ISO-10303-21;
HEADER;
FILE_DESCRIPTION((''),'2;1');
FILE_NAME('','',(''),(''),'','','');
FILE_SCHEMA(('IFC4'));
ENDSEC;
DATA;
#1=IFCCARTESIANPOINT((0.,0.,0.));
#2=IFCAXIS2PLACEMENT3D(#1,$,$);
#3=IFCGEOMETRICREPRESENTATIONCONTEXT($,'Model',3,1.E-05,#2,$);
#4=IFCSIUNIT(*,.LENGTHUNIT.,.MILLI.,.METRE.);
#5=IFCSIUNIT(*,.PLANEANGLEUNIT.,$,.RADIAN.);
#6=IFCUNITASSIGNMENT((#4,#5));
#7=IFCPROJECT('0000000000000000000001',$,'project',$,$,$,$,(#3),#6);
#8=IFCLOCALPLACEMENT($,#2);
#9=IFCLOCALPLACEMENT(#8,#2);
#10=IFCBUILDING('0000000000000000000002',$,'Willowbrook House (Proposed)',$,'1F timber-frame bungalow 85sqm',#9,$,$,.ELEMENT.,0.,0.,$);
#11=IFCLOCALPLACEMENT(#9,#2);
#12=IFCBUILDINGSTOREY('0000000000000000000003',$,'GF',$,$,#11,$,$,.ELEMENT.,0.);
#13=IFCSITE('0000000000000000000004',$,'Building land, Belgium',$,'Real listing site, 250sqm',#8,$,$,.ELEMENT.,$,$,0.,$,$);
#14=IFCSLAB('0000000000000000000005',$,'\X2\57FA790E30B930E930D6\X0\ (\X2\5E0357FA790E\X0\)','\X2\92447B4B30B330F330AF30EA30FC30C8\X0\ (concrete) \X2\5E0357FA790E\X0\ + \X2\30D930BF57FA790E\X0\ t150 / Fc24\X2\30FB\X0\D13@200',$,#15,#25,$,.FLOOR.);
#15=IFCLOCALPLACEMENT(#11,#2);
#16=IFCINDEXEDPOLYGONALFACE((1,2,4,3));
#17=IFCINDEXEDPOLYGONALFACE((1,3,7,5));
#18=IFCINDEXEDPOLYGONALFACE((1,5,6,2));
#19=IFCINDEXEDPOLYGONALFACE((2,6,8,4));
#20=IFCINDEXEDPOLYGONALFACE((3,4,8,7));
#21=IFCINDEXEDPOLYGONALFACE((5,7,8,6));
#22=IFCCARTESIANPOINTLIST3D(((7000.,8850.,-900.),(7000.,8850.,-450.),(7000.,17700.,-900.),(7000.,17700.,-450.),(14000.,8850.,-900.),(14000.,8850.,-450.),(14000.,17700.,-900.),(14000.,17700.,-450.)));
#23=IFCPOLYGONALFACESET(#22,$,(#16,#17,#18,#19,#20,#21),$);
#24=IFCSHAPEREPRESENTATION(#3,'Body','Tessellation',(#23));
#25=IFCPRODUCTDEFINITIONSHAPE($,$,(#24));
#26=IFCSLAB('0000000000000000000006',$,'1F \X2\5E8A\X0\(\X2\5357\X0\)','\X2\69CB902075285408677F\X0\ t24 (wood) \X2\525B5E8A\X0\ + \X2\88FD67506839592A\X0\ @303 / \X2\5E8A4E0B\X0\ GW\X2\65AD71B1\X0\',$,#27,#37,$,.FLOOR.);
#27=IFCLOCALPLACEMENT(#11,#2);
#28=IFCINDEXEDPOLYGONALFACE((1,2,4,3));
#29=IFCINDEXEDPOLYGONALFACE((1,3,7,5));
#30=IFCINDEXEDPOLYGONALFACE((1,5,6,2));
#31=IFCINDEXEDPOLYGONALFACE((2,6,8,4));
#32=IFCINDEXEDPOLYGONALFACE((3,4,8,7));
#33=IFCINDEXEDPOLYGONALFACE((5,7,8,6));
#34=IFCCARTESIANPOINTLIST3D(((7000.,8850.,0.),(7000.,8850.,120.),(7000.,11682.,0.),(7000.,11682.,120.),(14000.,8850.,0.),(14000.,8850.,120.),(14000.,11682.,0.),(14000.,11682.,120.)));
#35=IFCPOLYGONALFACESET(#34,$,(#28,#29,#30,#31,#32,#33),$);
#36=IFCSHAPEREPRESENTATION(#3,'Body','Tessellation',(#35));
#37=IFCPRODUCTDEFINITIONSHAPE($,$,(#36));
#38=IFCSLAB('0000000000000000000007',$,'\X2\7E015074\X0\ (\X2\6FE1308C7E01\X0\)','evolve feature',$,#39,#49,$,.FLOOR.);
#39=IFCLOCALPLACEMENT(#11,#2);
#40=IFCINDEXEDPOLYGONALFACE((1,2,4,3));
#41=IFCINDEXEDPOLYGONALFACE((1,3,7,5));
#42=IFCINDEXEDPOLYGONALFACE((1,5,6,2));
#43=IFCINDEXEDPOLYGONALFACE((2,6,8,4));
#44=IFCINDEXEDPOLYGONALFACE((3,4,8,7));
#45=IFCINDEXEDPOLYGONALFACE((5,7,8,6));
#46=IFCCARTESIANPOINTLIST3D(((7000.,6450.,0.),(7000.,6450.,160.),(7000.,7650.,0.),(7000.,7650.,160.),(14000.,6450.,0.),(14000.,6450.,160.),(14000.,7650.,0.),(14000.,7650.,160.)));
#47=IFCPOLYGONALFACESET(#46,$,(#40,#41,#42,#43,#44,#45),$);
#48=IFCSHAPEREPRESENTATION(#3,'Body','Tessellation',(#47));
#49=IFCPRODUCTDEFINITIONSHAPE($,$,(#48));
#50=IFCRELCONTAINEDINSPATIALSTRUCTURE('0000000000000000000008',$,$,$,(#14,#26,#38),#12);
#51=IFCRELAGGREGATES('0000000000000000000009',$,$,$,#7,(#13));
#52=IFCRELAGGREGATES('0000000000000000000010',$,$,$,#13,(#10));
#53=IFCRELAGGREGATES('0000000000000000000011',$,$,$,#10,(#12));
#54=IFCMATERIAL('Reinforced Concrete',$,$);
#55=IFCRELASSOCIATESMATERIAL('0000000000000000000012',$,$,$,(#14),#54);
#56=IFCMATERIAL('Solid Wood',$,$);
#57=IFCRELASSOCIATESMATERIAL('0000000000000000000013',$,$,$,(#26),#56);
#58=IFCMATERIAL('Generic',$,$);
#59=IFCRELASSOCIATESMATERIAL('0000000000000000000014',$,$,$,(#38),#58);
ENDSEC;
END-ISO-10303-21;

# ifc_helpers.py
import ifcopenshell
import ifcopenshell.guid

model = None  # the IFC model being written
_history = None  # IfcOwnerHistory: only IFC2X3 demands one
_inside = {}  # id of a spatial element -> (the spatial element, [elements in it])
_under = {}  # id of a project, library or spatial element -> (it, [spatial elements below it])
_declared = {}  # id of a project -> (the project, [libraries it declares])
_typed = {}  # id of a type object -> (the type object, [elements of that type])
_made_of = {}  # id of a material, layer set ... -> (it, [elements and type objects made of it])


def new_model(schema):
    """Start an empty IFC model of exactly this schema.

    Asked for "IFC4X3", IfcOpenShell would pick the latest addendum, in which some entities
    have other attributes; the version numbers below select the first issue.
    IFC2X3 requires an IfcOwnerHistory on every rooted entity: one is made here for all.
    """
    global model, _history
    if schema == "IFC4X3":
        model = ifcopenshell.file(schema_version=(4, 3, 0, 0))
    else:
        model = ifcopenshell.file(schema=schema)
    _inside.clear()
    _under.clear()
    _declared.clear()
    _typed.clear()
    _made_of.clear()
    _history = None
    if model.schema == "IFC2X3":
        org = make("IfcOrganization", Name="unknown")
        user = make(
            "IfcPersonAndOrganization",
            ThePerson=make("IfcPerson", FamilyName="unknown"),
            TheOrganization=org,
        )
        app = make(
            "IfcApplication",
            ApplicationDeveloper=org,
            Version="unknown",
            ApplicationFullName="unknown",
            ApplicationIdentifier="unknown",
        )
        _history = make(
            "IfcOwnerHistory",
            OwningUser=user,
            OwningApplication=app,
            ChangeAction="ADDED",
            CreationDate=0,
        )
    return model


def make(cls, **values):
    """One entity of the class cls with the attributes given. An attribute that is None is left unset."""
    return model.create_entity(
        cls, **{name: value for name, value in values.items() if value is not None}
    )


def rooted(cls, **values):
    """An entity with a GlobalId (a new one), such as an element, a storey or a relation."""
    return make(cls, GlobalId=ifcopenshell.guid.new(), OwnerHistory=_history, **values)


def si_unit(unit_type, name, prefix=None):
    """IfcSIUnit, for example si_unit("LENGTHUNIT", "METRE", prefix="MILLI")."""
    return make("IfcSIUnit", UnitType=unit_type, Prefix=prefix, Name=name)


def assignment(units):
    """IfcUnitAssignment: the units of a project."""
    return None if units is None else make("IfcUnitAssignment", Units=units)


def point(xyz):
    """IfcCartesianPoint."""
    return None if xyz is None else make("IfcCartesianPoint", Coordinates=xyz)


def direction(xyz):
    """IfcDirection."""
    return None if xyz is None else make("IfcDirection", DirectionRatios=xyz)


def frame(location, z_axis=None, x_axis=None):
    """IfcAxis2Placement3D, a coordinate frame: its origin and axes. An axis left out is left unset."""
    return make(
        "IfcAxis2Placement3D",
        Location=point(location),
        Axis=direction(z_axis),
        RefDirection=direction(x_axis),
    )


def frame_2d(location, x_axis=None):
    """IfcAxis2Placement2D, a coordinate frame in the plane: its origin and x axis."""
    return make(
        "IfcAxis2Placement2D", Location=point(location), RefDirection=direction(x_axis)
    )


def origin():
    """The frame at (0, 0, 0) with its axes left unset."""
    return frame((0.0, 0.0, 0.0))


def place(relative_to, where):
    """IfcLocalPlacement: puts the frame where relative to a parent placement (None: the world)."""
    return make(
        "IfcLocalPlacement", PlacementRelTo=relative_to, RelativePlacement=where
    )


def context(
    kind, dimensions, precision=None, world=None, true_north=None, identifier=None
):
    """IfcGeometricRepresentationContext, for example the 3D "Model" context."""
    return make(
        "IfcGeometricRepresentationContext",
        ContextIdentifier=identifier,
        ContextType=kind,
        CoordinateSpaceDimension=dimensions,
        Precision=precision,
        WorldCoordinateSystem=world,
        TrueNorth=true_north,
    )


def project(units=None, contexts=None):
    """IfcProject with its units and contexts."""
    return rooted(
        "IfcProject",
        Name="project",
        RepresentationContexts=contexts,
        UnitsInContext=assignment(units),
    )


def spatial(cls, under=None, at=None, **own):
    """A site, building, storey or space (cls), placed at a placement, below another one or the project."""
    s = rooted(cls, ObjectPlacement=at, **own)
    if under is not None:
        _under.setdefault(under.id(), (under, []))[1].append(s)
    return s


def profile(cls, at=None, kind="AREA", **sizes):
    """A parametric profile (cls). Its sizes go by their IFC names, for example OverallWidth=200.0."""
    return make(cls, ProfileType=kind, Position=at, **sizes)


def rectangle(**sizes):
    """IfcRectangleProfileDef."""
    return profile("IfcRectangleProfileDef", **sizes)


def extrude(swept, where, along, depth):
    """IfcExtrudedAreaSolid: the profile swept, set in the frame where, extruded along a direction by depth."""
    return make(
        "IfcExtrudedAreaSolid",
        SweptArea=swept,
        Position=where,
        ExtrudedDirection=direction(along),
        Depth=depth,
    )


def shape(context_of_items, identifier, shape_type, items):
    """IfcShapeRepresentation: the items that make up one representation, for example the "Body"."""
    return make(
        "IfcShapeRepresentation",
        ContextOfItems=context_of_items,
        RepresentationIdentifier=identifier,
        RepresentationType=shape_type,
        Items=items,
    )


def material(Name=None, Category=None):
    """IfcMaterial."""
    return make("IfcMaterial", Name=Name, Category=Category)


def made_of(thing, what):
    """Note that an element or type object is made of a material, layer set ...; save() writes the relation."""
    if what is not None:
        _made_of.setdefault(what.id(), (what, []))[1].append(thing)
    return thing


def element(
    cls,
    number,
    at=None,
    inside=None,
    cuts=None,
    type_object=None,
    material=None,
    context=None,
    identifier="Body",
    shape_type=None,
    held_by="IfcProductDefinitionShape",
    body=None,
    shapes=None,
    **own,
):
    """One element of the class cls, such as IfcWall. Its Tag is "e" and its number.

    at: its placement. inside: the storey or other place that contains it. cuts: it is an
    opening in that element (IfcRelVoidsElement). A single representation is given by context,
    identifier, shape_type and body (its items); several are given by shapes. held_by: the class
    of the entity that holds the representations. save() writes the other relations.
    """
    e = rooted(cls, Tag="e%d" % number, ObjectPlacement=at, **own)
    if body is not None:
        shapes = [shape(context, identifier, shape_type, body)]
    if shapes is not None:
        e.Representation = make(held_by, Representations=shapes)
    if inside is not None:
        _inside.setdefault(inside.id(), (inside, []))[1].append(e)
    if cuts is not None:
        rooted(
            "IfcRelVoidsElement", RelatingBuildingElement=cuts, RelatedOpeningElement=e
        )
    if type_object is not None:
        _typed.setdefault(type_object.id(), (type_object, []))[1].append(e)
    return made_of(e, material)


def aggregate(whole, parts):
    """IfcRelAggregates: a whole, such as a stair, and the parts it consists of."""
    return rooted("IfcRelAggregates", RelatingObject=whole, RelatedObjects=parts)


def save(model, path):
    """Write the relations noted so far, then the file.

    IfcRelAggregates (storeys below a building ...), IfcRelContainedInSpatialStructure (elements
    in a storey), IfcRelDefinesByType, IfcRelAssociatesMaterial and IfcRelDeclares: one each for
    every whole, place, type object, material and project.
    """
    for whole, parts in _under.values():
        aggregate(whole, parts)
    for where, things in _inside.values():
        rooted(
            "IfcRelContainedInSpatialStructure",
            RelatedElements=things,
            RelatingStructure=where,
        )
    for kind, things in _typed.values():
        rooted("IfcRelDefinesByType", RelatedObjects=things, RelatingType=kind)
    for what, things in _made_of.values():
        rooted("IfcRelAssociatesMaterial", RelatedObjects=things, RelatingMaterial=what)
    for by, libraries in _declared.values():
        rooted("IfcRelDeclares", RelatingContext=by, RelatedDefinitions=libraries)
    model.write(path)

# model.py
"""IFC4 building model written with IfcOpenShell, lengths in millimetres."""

from ifc_helpers import new_model, si_unit, frame, frame_2d, origin, place, context, project, spatial, rectangle, extrude, material, element, save


model = new_model("IFC4")

# Units and contexts
model_context = context("Model", 3, precision=1e-05, world=origin())
ifc_project = project(units=[si_unit("LENGTHUNIT", "METRE", prefix="MILLI"), si_unit("PLANEANGLEUNIT", "RADIAN")], contexts=[model_context])

# Site, building, storey
site_placement = place(None, origin())
site = spatial("IfcSite", under=ifc_project, at=site_placement, Name="Building land, Belgium", ObjectType="Real listing site, 250sqm", CompositionType="ELEMENT", RefElevation=0.0)
building_placement = place(site_placement, origin())
building = spatial("IfcBuilding", under=site, at=building_placement, Name="Willowbrook House (Proposed)", ObjectType="1F timber-frame bungalow 85sqm", CompositionType="ELEMENT", ElevationOfRefHeight=0.0, ElevationOfTerrain=0.0)
storey_placement = place(building_placement, origin())
storey = spatial("IfcBuildingStorey", under=building, at=storey_placement, Name="GF", CompositionType="ELEMENT", Elevation=0.0)

# Slabs
ifc_material_1 = material(Name="Reinforced Concrete")
slab_1_placement = place(storey_placement, frame((3500.0, 4425.0, -450.0)))
element("IfcSlab", 1, at=slab_1_placement, inside=storey, material=ifc_material_1, Name="基礎スラブ (布基礎)", Description="鉄筋コンクリート (concrete) 布基礎 + ベタ基礎 t150 / Fc24・D13@200", PredefinedType="FLOOR", context=model_context, shape_type="SweptSolid", body=[
    extrude(rectangle(XDim=7000.0, YDim=8850.0, at=frame_2d((3500.0, 4425.0))), frame((3500.0, 4425.0, -450.0)), (0.0, 0.0, 1.0), 450.0),
])
ifc_material_2 = material(Name="Solid Wood")
slab_2_placement = place(storey_placement, frame((3500.0, 4425.0, 0.0)))
element("IfcSlab", 2, at=slab_2_placement, inside=storey, material=ifc_material_2, Name="1F 床(南)", Description="構造用合板 t24 (wood) 剛床 + 製材根太 @303 / 床下 GW断熱", PredefinedType="FLOOR", context=model_context, shape_type="SweptSolid", body=[
    extrude(rectangle(XDim=7000.0, YDim=2832.0, at=frame_2d((3500.0, 1416.0))), frame((3500.0, 4425.0, 0.0)), (0.0, 0.0, 1.0), 120.0),
])
ifc_material_3 = material(Name="Generic")
slab_3_placement = place(storey_placement, frame((3500.0, 3225.0, 0.0)))
element("IfcSlab", 3, at=slab_3_placement, inside=storey, material=ifc_material_3, Name="縁側 (濡れ縁)", Description="evolve feature", PredefinedType="FLOOR", context=model_context, shape_type="SweptSolid", body=[
    extrude(rectangle(XDim=7000.0, YDim=1200.0, at=frame_2d((3500.0, 600.0))), frame((3500.0, 3225.0, 0.0)), (0.0, 0.0, 1.0), 160.0),
])

save(model, "model.ifc")
